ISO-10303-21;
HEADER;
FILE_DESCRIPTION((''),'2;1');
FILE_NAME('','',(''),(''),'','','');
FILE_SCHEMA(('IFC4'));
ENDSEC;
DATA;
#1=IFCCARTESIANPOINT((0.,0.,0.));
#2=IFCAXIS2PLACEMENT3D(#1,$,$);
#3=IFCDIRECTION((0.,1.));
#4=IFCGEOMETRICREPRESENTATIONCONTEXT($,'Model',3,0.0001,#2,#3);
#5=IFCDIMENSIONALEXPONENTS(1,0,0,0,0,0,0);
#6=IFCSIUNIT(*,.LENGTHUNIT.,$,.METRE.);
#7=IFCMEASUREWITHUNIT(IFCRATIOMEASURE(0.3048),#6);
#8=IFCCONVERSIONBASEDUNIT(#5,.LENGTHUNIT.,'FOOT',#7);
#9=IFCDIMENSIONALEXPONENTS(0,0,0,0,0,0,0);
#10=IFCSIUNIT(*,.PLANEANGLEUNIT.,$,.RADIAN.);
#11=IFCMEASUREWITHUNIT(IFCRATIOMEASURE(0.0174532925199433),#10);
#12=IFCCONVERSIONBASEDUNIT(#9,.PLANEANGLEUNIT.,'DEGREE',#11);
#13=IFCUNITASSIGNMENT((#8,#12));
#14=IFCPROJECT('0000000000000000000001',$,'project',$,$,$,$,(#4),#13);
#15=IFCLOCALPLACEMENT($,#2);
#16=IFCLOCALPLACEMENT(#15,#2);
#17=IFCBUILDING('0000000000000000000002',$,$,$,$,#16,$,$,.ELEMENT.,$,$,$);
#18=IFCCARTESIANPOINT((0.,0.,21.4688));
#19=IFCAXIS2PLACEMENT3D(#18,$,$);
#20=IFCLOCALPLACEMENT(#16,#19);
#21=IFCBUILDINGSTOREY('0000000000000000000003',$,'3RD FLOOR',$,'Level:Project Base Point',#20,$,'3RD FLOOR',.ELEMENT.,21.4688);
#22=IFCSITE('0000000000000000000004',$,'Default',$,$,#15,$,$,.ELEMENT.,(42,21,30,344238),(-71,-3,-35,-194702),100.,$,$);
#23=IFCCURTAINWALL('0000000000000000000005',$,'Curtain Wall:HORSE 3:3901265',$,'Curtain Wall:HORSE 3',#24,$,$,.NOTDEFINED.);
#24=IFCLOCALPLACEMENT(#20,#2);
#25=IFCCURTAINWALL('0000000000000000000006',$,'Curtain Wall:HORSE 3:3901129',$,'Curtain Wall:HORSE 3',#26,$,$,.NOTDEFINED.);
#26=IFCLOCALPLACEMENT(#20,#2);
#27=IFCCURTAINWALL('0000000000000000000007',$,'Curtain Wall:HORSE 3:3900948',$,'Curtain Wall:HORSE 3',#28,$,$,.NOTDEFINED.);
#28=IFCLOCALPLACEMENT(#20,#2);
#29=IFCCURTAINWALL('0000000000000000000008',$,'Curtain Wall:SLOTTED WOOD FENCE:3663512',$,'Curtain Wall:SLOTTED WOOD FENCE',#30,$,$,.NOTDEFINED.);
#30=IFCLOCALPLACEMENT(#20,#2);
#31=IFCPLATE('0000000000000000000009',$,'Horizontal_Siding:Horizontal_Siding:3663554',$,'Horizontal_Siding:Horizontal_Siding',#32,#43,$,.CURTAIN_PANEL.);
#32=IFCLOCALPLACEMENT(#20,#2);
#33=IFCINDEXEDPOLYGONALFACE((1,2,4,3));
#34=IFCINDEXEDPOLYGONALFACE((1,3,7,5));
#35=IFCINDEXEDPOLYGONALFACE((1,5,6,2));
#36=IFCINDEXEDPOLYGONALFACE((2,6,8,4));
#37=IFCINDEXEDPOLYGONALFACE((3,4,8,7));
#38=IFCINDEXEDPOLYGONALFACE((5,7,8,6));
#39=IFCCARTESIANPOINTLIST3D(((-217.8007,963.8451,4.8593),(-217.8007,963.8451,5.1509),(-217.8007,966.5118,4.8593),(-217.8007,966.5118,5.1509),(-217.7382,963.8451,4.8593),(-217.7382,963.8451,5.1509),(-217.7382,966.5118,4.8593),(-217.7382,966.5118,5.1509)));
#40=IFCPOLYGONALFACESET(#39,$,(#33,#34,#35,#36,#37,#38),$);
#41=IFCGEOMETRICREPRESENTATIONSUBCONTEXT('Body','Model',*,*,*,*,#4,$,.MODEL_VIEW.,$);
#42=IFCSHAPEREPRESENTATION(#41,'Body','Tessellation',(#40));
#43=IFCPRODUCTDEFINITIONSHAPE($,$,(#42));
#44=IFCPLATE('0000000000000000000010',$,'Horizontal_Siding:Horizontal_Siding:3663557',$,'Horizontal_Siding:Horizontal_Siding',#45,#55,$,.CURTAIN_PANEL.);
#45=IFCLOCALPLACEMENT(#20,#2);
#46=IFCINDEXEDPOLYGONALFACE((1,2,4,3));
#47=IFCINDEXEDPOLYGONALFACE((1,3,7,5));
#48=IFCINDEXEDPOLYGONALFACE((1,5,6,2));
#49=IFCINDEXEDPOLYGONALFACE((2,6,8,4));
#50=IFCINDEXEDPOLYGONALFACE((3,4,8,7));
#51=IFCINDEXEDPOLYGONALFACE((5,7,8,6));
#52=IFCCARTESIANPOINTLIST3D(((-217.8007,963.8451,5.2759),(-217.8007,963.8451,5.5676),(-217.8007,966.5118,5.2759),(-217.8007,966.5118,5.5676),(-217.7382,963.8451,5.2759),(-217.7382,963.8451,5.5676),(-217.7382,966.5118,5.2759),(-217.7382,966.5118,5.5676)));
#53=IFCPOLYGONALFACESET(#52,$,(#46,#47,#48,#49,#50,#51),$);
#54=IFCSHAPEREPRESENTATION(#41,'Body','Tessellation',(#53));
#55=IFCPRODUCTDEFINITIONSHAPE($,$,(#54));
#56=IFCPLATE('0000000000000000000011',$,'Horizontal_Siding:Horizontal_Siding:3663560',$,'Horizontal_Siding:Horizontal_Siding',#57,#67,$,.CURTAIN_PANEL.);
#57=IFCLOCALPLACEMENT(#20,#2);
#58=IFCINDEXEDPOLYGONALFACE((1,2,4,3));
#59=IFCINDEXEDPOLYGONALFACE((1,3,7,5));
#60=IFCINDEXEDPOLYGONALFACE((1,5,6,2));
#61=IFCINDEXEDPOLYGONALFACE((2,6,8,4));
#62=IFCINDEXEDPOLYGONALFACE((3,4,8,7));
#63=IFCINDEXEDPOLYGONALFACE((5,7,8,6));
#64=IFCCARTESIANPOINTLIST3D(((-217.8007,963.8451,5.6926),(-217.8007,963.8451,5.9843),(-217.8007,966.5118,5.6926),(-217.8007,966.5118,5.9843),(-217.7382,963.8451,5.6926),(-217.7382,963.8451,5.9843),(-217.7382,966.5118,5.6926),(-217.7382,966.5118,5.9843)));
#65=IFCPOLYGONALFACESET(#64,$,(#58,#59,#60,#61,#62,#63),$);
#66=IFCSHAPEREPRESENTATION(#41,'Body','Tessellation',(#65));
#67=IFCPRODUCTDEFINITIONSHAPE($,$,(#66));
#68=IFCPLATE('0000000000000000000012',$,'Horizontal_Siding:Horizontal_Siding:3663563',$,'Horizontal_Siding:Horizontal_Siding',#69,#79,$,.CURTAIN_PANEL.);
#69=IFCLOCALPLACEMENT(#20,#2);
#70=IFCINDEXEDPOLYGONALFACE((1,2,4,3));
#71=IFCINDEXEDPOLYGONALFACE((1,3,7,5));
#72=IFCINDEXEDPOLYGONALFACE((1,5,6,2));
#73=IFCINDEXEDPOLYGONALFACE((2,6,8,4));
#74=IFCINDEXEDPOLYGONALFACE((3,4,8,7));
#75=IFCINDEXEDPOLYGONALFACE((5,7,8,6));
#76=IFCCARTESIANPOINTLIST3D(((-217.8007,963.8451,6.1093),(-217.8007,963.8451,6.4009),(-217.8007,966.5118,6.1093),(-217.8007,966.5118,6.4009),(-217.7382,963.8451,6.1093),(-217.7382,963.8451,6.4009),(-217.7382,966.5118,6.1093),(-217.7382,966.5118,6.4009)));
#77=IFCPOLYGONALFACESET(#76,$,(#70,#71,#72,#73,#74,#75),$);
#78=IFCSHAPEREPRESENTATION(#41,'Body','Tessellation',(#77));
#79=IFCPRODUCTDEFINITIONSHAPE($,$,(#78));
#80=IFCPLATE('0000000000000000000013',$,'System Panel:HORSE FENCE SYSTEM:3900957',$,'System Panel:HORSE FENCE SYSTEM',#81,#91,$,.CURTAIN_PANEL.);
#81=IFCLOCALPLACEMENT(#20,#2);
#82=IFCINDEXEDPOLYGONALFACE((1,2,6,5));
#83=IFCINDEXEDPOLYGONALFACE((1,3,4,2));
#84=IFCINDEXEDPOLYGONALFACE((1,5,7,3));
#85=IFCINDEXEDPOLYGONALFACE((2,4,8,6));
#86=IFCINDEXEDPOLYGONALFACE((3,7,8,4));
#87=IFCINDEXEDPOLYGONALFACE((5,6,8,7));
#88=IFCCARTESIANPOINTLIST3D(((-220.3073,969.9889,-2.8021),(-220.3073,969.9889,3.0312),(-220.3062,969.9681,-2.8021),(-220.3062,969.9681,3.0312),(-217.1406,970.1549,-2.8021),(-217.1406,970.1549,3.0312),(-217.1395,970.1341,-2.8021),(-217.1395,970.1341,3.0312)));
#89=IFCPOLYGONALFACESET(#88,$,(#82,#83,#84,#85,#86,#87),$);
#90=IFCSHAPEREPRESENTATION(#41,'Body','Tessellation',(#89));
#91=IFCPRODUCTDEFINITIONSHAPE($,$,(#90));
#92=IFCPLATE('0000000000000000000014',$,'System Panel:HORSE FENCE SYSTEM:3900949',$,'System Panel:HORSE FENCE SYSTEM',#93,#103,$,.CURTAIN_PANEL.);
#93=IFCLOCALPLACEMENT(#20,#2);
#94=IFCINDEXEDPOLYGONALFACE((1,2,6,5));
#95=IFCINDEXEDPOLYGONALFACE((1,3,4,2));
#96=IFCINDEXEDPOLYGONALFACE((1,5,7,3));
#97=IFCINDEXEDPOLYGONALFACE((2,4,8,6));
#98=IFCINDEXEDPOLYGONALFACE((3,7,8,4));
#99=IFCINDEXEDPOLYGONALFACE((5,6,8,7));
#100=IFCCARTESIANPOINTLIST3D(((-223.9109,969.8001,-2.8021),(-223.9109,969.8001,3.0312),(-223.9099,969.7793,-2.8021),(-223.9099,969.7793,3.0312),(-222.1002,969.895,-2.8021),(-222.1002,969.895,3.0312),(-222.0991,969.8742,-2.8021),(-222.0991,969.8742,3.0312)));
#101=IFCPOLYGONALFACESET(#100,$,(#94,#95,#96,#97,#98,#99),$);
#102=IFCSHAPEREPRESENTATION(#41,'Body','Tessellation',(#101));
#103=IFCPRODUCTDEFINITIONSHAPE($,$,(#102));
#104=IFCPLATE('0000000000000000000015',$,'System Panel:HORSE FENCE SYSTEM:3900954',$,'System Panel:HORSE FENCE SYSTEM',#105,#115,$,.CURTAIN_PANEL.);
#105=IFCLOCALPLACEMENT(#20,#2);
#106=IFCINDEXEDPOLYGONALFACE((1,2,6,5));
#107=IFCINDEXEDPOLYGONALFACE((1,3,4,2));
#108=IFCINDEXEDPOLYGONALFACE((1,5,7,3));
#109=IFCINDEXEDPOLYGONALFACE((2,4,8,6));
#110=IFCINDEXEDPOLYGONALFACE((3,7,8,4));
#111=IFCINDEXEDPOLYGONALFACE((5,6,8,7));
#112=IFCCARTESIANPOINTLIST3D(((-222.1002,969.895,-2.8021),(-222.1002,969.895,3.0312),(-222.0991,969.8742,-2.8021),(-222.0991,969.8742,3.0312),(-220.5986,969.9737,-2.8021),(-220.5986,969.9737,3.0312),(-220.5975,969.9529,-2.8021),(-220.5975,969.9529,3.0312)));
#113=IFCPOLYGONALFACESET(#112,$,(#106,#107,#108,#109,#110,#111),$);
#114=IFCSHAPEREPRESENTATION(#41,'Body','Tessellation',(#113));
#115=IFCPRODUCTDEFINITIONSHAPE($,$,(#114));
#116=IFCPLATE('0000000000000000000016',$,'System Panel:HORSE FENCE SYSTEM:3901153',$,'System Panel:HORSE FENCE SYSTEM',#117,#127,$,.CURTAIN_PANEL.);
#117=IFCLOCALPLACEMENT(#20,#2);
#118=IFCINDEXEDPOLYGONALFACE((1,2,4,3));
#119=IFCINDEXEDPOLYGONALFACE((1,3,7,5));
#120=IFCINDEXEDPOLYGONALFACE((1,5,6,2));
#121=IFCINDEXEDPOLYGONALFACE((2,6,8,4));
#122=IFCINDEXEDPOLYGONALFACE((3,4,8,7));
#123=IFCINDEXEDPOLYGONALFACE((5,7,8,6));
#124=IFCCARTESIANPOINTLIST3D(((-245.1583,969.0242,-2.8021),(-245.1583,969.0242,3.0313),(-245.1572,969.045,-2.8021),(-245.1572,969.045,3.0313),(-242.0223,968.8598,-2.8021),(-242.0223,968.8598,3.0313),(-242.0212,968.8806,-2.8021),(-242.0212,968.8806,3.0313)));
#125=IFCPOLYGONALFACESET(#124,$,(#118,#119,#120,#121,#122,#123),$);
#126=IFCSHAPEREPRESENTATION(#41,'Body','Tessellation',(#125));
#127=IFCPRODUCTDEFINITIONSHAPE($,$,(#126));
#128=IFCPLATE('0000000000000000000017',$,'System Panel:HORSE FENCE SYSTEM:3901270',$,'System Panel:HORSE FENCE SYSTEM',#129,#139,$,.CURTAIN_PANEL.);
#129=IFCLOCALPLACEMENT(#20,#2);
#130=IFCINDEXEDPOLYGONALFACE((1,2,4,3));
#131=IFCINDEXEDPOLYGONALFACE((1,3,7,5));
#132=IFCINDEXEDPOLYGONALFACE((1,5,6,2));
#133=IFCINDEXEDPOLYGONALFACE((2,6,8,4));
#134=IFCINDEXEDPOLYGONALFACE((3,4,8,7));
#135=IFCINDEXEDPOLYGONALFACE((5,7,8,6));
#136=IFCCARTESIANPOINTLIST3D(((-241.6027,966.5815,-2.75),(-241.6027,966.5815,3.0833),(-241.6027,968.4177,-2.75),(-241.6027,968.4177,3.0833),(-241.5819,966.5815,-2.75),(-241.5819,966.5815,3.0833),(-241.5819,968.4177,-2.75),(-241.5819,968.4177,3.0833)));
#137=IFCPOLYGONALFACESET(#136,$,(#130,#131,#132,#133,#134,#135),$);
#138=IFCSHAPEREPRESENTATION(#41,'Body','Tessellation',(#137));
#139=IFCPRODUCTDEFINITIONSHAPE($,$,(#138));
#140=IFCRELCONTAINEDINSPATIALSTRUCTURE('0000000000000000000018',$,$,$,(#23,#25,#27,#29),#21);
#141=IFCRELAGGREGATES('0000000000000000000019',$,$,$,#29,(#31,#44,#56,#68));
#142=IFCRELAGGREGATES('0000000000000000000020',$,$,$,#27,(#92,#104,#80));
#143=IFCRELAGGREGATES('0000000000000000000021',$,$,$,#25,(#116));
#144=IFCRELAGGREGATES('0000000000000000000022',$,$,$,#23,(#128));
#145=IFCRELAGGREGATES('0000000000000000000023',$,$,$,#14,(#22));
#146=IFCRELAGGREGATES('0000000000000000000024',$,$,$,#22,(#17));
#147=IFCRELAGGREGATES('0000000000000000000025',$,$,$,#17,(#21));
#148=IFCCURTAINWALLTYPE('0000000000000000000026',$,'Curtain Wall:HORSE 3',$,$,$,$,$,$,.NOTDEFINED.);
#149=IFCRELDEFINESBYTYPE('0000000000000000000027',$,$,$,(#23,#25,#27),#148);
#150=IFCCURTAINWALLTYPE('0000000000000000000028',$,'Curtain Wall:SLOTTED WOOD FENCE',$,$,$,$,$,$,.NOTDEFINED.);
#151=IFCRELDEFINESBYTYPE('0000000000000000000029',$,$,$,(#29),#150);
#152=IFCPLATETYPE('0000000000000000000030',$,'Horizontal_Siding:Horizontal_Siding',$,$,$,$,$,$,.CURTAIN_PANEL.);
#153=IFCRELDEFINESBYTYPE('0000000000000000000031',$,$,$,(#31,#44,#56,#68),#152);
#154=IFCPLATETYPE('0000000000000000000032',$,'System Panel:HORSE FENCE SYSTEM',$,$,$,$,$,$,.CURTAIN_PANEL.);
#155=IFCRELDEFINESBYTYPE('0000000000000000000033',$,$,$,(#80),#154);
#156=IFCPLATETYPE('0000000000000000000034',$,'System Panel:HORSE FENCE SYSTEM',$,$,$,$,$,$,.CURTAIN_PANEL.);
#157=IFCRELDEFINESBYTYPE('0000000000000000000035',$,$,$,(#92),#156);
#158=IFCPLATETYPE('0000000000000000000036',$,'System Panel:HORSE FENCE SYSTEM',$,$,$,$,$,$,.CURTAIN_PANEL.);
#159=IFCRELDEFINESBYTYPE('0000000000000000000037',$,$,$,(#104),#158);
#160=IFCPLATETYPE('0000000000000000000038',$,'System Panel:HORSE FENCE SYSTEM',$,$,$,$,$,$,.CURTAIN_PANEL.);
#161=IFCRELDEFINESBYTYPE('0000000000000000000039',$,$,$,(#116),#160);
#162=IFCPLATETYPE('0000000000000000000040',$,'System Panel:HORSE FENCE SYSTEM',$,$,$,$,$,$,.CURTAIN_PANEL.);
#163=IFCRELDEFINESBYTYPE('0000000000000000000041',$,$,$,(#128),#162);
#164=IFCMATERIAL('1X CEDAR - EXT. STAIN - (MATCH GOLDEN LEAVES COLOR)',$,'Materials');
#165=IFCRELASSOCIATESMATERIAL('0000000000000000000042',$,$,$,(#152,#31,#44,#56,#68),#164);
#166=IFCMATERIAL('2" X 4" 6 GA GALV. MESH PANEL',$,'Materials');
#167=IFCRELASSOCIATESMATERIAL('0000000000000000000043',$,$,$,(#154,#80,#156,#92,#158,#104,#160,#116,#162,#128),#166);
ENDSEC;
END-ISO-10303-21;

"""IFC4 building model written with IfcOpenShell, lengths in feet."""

from ifc_helpers import new_model, entity, si_unit, converted_unit, direction, frame, frame_2d, origin, origin_2d_with_axis, place, context, subcontext, project, spatial, rectangle, extrude, source, transform, mapped, material, type_object, type_shapes, element, aggregate, save


model = new_model("IFC4")

# Units and contexts
model_context = context("Model", 3, precision=0.0001, world=origin(), true_north=direction((0.0, 1.0)))
body_context = subcontext(model_context, "Body", "Model", "MODEL_VIEW")
ifc_project = project(units=[converted_unit("LENGTHUNIT", "FOOT", entity("IfcRatioMeasure", 0.3048), si_unit("LENGTHUNIT", "METRE"), dimensions=[1, 0, 0, 0, 0, 0, 0]), converted_unit("PLANEANGLEUNIT", "DEGREE", entity("IfcRatioMeasure", 0.0174532925199433), si_unit("PLANEANGLEUNIT", "RADIAN"), dimensions=[0, 0, 0, 0, 0, 0, 0])], contexts=[model_context])

# Site, building, storey
site_placement = place(None, origin())
site = spatial("IfcSite", under=ifc_project, at=site_placement, Name="Default", CompositionType="ELEMENT", RefLatitude=(42, 21, 30, 344238), RefLongitude=(-71, -3, -35, -194702), RefElevation=100.0)
building_placement = place(site_placement, origin())
building = spatial("IfcBuilding", under=site, at=building_placement, CompositionType="ELEMENT")
storey_placement = place(building_placement, frame((0.0, 0.0, 21.4688)))
storey = spatial("IfcBuildingStorey", under=building, at=storey_placement, Name="3RD FLOOR", ObjectType="Level:Project Base Point", LongName="3RD FLOOR", CompositionType="ELEMENT", Elevation=21.4688)

# Curtain wall
curtain_wall_type_1 = type_object("IfcCurtainWallType", Name="Curtain Wall:HORSE 3", PredefinedType="NOTDEFINED")
curtain_wall_1_placement = place(storey_placement, frame((0.0, 0.0, -21.4688)))
curtain_wall_1 = element("IfcCurtainWall", 1, at=curtain_wall_1_placement, inside=storey, type_object=curtain_wall_type_1, Name="Curtain Wall:HORSE 3:3901265", ObjectType="Curtain Wall:HORSE 3", PredefinedType="NOTDEFINED")

# Curtain wall
curtain_wall_2_placement = place(storey_placement, frame((0.0, 0.0, -21.4688)))
curtain_wall_2 = element("IfcCurtainWall", 2, at=curtain_wall_2_placement, inside=storey, type_object=curtain_wall_type_1, Name="Curtain Wall:HORSE 3:3901129", ObjectType="Curtain Wall:HORSE 3", PredefinedType="NOTDEFINED")

# Shared definitions
curtain_wall_type_2 = type_object("IfcCurtainWallType", Name="Curtain Wall:SLOTTED WOOD FENCE", PredefinedType="NOTDEFINED")

# Curtain wall
curtain_wall_3_placement = place(storey_placement, frame((0.0, 0.0, -21.4688)))
curtain_wall_3 = element("IfcCurtainWall", 3, at=curtain_wall_3_placement, inside=storey, type_object=curtain_wall_type_1, Name="Curtain Wall:HORSE 3:3900948", ObjectType="Curtain Wall:HORSE 3", PredefinedType="NOTDEFINED")

# Curtain wall, plates
curtain_wall_4_placement = place(storey_placement, frame((0.0, 0.0, -21.4688)))
curtain_wall_4 = element("IfcCurtainWall", 4, at=curtain_wall_4_placement, inside=storey, type_object=curtain_wall_type_2, Name="Curtain Wall:SLOTTED WOOD FENCE:3663512", ObjectType="Curtain Wall:SLOTTED WOOD FENCE", PredefinedType="NOTDEFINED")
ifc_material_1 = material(Name="1X CEDAR - EXT. STAIN - (MATCH GOLDEN LEAVES COLOR)", Category="Materials")
plate_type_1 = type_object("IfcPlateType", Name="Horizontal_Siding:Horizontal_Siding", PredefinedType="CURTAIN_PANEL", material=ifc_material_1)
shared_shape_1 = source(origin(), body_context, "Body", "SweptSolid", [
    extrude(rectangle(XDim=2.6667, YDim=0.0625, at=origin_2d_with_axis()), frame((1.3333, 0.0312, 0.0), z_axis=(0.0, 0.0, 1.0), x_axis=(-1.0, 0.0, 0.0)), (0.0, 0.0, 1.0), 0.2917),
])
type_shapes(plate_type_1, [shared_shape_1])
plate_1_placement = place(curtain_wall_4_placement, frame((-217.8007, 966.5118, 26.328), z_axis=(0.0, 0.0, 1.0), x_axis=(0.0, -1.0, 0.0)))
plate_1 = element("IfcPlate", 5, at=plate_1_placement, type_object=plate_type_1, material=ifc_material_1, Name="Horizontal_Siding:Horizontal_Siding:3663554", ObjectType="Horizontal_Siding:Horizontal_Siding", PredefinedType="CURTAIN_PANEL", context=body_context, shape_type="MappedRepresentation", body=[
    mapped(shared_shape_1, transform((0.0, 0.0, 0.0), scale=1.0)),
])
plate_2_placement = place(curtain_wall_4_placement, frame((-217.8007, 966.5118, 26.7447), z_axis=(0.0, 0.0, 1.0), x_axis=(0.0, -1.0, 0.0)))
plate_2 = element("IfcPlate", 6, at=plate_2_placement, type_object=plate_type_1, material=ifc_material_1, Name="Horizontal_Siding:Horizontal_Siding:3663557", ObjectType="Horizontal_Siding:Horizontal_Siding", PredefinedType="CURTAIN_PANEL", context=body_context, shape_type="MappedRepresentation", body=[
    mapped(shared_shape_1, transform((0.0, 0.0, 0.0), scale=1.0)),
])
plate_3_placement = place(curtain_wall_4_placement, frame((-217.8007, 966.5118, 27.1613), z_axis=(0.0, 0.0, 1.0), x_axis=(0.0, -1.0, 0.0)))
plate_3 = element("IfcPlate", 7, at=plate_3_placement, type_object=plate_type_1, material=ifc_material_1, Name="Horizontal_Siding:Horizontal_Siding:3663560", ObjectType="Horizontal_Siding:Horizontal_Siding", PredefinedType="CURTAIN_PANEL", context=body_context, shape_type="MappedRepresentation", body=[
    mapped(shared_shape_1, transform((0.0, 0.0, 0.0), scale=1.0)),
])
plate_4_placement = place(curtain_wall_4_placement, frame((-217.8007, 966.5118, 27.578), z_axis=(0.0, 0.0, 1.0), x_axis=(0.0, -1.0, 0.0)))
plate_4 = element("IfcPlate", 8, at=plate_4_placement, type_object=plate_type_1, material=ifc_material_1, Name="Horizontal_Siding:Horizontal_Siding:3663563", ObjectType="Horizontal_Siding:Horizontal_Siding", PredefinedType="CURTAIN_PANEL", context=body_context, shape_type="MappedRepresentation", body=[
    mapped(shared_shape_1, transform((0.0, 0.0, 0.0), scale=1.0)),
])
aggregate(curtain_wall_4, [plate_1, plate_2, plate_3, plate_4])

# Plates
ifc_material_2 = material(Name="2\" X 4\" 6 GA GALV. MESH PANEL", Category="Materials")
plate_type_2 = type_object("IfcPlateType", Name="System Panel:HORSE FENCE SYSTEM", PredefinedType="CURTAIN_PANEL", material=ifc_material_2)
shared_shape_2 = source(origin(), body_context, "Body", "SweptSolid", [
    extrude(rectangle(XDim=0.0208, YDim=3.1711, at=frame_2d((0.0, 0.0), x_axis=(1.0, 0.0))), frame((1.5855, 0.0104, 0.0), z_axis=(0.0, 0.0, 1.0), x_axis=(0.0, 1.0, 0.0)), (0.0, 0.0, 1.0), 5.8333),
])
type_shapes(plate_type_2, [shared_shape_2])
plate_5_placement = place(curtain_wall_3_placement, frame((-220.3062, 969.9681, 18.6667), z_axis=(0.0, 0.0, 1.0), x_axis=(0.99863, 0.052336, 0.0)))
plate_5 = element("IfcPlate", 9, at=plate_5_placement, type_object=plate_type_2, material=ifc_material_2, Name="System Panel:HORSE FENCE SYSTEM:3900957", ObjectType="System Panel:HORSE FENCE SYSTEM", PredefinedType="CURTAIN_PANEL", context=body_context, shape_type="MappedRepresentation", body=[
    mapped(shared_shape_2, transform((0.0, 0.0, 0.0), scale=1.0)),
])
plate_type_3 = type_object("IfcPlateType", Name="System Panel:HORSE FENCE SYSTEM", PredefinedType="CURTAIN_PANEL", material=ifc_material_2)
shared_shape_3 = source(origin(), body_context, "Body", "SweptSolid", [
    extrude(rectangle(XDim=0.0208, YDim=1.8133, at=frame_2d((0.0, 0.0), x_axis=(1.0, 0.0))), frame((0.9066, 0.0104, 0.0), z_axis=(0.0, 0.0, 1.0), x_axis=(0.0, 1.0, 0.0)), (0.0, 0.0, 1.0), 5.8333),
])
type_shapes(plate_type_3, [shared_shape_3])
plate_6_placement = place(curtain_wall_3_placement, frame((-223.9099, 969.7793, 18.6667), z_axis=(0.0, 0.0, 1.0), x_axis=(0.99863, 0.052336, 0.0)))
plate_6 = element("IfcPlate", 10, at=plate_6_placement, type_object=plate_type_3, material=ifc_material_2, Name="System Panel:HORSE FENCE SYSTEM:3900949", ObjectType="System Panel:HORSE FENCE SYSTEM", PredefinedType="CURTAIN_PANEL", context=body_context, shape_type="MappedRepresentation", body=[
    mapped(shared_shape_3, transform((0.0, 0.0, 0.0), scale=1.0)),
])
plate_type_4 = type_object("IfcPlateType", Name="System Panel:HORSE FENCE SYSTEM", PredefinedType="CURTAIN_PANEL", material=ifc_material_2)
shared_shape_4 = source(origin(), body_context, "Body", "SweptSolid", [
    extrude(rectangle(XDim=0.0208, YDim=1.5037, at=frame_2d((0.0, 0.0), x_axis=(1.0, 0.0))), frame((0.7518, 0.0104, 0.0), z_axis=(0.0, 0.0, 1.0), x_axis=(0.0, 1.0, 0.0)), (0.0, 0.0, 1.0), 5.8333),
])
type_shapes(plate_type_4, [shared_shape_4])
plate_7_placement = place(curtain_wall_3_placement, frame((-222.0991, 969.8742, 18.6667), z_axis=(0.0, 0.0, 1.0), x_axis=(0.99863, 0.052336, 0.0)))
plate_7 = element("IfcPlate", 11, at=plate_7_placement, type_object=plate_type_4, material=ifc_material_2, Name="System Panel:HORSE FENCE SYSTEM:3900954", ObjectType="System Panel:HORSE FENCE SYSTEM", PredefinedType="CURTAIN_PANEL", context=body_context, shape_type="MappedRepresentation", body=[
    mapped(shared_shape_4, transform((0.0, 0.0, 0.0), scale=1.0)),
])
aggregate(curtain_wall_3, [plate_6, plate_7, plate_5])
plate_type_5 = type_object("IfcPlateType", Name="System Panel:HORSE FENCE SYSTEM", PredefinedType="CURTAIN_PANEL", material=ifc_material_2)
shared_shape_5 = source(origin(), body_context, "Body", "SweptSolid", [
    extrude(rectangle(XDim=0.0208, YDim=3.1402, at=frame_2d((0.0, 0.0), x_axis=(1.0, 0.0))), frame((1.5701, 0.0104, 0.0), z_axis=(0.0, 0.0, 1.0), x_axis=(0.0, 1.0, 0.0)), (0.0, 0.0, 1.0), 5.8333),
])
type_shapes(plate_type_5, [shared_shape_5])
plate_8_placement = place(curtain_wall_2_placement, frame((-245.1583, 969.0242, 18.6667), z_axis=(0.0, 0.0, 1.0), x_axis=(0.99863, -0.052336, 0.0)))
plate_8 = element("IfcPlate", 12, at=plate_8_placement, type_object=plate_type_5, material=ifc_material_2, Name="System Panel:HORSE FENCE SYSTEM:3901153", ObjectType="System Panel:HORSE FENCE SYSTEM", PredefinedType="CURTAIN_PANEL", context=body_context, shape_type="MappedRepresentation", body=[
    mapped(shared_shape_5, transform((0.0, 0.0, 0.0), scale=1.0)),
])
aggregate(curtain_wall_2, [plate_8])
plate_type_6 = type_object("IfcPlateType", Name="System Panel:HORSE FENCE SYSTEM", PredefinedType="CURTAIN_PANEL", material=ifc_material_2)
shared_shape_6 = source(origin(), body_context, "Body", "SweptSolid", [
    extrude(rectangle(XDim=0.0208, YDim=1.8362, at=frame_2d((0.0, 0.0), x_axis=(1.0, 0.0))), frame((0.9181, 0.0104, 0.0), z_axis=(0.0, 0.0, 1.0), x_axis=(0.0, 1.0, 0.0)), (0.0, 0.0, 1.0), 5.8333),
])
type_shapes(plate_type_6, [shared_shape_6])
plate_9_placement = place(curtain_wall_1_placement, frame((-241.5819, 966.5815, 18.7188), z_axis=(0.0, 0.0, 1.0), x_axis=(0.0, 1.0, 0.0)))
plate_9 = element("IfcPlate", 13, at=plate_9_placement, type_object=plate_type_6, material=ifc_material_2, Name="System Panel:HORSE FENCE SYSTEM:3901270", ObjectType="System Panel:HORSE FENCE SYSTEM", PredefinedType="CURTAIN_PANEL", context=body_context, shape_type="MappedRepresentation", body=[
    mapped(shared_shape_6, transform((0.0, 0.0, 0.0), scale=1.0)),
])
aggregate(curtain_wall_1, [plate_9])

save(model, "model.ifc")
